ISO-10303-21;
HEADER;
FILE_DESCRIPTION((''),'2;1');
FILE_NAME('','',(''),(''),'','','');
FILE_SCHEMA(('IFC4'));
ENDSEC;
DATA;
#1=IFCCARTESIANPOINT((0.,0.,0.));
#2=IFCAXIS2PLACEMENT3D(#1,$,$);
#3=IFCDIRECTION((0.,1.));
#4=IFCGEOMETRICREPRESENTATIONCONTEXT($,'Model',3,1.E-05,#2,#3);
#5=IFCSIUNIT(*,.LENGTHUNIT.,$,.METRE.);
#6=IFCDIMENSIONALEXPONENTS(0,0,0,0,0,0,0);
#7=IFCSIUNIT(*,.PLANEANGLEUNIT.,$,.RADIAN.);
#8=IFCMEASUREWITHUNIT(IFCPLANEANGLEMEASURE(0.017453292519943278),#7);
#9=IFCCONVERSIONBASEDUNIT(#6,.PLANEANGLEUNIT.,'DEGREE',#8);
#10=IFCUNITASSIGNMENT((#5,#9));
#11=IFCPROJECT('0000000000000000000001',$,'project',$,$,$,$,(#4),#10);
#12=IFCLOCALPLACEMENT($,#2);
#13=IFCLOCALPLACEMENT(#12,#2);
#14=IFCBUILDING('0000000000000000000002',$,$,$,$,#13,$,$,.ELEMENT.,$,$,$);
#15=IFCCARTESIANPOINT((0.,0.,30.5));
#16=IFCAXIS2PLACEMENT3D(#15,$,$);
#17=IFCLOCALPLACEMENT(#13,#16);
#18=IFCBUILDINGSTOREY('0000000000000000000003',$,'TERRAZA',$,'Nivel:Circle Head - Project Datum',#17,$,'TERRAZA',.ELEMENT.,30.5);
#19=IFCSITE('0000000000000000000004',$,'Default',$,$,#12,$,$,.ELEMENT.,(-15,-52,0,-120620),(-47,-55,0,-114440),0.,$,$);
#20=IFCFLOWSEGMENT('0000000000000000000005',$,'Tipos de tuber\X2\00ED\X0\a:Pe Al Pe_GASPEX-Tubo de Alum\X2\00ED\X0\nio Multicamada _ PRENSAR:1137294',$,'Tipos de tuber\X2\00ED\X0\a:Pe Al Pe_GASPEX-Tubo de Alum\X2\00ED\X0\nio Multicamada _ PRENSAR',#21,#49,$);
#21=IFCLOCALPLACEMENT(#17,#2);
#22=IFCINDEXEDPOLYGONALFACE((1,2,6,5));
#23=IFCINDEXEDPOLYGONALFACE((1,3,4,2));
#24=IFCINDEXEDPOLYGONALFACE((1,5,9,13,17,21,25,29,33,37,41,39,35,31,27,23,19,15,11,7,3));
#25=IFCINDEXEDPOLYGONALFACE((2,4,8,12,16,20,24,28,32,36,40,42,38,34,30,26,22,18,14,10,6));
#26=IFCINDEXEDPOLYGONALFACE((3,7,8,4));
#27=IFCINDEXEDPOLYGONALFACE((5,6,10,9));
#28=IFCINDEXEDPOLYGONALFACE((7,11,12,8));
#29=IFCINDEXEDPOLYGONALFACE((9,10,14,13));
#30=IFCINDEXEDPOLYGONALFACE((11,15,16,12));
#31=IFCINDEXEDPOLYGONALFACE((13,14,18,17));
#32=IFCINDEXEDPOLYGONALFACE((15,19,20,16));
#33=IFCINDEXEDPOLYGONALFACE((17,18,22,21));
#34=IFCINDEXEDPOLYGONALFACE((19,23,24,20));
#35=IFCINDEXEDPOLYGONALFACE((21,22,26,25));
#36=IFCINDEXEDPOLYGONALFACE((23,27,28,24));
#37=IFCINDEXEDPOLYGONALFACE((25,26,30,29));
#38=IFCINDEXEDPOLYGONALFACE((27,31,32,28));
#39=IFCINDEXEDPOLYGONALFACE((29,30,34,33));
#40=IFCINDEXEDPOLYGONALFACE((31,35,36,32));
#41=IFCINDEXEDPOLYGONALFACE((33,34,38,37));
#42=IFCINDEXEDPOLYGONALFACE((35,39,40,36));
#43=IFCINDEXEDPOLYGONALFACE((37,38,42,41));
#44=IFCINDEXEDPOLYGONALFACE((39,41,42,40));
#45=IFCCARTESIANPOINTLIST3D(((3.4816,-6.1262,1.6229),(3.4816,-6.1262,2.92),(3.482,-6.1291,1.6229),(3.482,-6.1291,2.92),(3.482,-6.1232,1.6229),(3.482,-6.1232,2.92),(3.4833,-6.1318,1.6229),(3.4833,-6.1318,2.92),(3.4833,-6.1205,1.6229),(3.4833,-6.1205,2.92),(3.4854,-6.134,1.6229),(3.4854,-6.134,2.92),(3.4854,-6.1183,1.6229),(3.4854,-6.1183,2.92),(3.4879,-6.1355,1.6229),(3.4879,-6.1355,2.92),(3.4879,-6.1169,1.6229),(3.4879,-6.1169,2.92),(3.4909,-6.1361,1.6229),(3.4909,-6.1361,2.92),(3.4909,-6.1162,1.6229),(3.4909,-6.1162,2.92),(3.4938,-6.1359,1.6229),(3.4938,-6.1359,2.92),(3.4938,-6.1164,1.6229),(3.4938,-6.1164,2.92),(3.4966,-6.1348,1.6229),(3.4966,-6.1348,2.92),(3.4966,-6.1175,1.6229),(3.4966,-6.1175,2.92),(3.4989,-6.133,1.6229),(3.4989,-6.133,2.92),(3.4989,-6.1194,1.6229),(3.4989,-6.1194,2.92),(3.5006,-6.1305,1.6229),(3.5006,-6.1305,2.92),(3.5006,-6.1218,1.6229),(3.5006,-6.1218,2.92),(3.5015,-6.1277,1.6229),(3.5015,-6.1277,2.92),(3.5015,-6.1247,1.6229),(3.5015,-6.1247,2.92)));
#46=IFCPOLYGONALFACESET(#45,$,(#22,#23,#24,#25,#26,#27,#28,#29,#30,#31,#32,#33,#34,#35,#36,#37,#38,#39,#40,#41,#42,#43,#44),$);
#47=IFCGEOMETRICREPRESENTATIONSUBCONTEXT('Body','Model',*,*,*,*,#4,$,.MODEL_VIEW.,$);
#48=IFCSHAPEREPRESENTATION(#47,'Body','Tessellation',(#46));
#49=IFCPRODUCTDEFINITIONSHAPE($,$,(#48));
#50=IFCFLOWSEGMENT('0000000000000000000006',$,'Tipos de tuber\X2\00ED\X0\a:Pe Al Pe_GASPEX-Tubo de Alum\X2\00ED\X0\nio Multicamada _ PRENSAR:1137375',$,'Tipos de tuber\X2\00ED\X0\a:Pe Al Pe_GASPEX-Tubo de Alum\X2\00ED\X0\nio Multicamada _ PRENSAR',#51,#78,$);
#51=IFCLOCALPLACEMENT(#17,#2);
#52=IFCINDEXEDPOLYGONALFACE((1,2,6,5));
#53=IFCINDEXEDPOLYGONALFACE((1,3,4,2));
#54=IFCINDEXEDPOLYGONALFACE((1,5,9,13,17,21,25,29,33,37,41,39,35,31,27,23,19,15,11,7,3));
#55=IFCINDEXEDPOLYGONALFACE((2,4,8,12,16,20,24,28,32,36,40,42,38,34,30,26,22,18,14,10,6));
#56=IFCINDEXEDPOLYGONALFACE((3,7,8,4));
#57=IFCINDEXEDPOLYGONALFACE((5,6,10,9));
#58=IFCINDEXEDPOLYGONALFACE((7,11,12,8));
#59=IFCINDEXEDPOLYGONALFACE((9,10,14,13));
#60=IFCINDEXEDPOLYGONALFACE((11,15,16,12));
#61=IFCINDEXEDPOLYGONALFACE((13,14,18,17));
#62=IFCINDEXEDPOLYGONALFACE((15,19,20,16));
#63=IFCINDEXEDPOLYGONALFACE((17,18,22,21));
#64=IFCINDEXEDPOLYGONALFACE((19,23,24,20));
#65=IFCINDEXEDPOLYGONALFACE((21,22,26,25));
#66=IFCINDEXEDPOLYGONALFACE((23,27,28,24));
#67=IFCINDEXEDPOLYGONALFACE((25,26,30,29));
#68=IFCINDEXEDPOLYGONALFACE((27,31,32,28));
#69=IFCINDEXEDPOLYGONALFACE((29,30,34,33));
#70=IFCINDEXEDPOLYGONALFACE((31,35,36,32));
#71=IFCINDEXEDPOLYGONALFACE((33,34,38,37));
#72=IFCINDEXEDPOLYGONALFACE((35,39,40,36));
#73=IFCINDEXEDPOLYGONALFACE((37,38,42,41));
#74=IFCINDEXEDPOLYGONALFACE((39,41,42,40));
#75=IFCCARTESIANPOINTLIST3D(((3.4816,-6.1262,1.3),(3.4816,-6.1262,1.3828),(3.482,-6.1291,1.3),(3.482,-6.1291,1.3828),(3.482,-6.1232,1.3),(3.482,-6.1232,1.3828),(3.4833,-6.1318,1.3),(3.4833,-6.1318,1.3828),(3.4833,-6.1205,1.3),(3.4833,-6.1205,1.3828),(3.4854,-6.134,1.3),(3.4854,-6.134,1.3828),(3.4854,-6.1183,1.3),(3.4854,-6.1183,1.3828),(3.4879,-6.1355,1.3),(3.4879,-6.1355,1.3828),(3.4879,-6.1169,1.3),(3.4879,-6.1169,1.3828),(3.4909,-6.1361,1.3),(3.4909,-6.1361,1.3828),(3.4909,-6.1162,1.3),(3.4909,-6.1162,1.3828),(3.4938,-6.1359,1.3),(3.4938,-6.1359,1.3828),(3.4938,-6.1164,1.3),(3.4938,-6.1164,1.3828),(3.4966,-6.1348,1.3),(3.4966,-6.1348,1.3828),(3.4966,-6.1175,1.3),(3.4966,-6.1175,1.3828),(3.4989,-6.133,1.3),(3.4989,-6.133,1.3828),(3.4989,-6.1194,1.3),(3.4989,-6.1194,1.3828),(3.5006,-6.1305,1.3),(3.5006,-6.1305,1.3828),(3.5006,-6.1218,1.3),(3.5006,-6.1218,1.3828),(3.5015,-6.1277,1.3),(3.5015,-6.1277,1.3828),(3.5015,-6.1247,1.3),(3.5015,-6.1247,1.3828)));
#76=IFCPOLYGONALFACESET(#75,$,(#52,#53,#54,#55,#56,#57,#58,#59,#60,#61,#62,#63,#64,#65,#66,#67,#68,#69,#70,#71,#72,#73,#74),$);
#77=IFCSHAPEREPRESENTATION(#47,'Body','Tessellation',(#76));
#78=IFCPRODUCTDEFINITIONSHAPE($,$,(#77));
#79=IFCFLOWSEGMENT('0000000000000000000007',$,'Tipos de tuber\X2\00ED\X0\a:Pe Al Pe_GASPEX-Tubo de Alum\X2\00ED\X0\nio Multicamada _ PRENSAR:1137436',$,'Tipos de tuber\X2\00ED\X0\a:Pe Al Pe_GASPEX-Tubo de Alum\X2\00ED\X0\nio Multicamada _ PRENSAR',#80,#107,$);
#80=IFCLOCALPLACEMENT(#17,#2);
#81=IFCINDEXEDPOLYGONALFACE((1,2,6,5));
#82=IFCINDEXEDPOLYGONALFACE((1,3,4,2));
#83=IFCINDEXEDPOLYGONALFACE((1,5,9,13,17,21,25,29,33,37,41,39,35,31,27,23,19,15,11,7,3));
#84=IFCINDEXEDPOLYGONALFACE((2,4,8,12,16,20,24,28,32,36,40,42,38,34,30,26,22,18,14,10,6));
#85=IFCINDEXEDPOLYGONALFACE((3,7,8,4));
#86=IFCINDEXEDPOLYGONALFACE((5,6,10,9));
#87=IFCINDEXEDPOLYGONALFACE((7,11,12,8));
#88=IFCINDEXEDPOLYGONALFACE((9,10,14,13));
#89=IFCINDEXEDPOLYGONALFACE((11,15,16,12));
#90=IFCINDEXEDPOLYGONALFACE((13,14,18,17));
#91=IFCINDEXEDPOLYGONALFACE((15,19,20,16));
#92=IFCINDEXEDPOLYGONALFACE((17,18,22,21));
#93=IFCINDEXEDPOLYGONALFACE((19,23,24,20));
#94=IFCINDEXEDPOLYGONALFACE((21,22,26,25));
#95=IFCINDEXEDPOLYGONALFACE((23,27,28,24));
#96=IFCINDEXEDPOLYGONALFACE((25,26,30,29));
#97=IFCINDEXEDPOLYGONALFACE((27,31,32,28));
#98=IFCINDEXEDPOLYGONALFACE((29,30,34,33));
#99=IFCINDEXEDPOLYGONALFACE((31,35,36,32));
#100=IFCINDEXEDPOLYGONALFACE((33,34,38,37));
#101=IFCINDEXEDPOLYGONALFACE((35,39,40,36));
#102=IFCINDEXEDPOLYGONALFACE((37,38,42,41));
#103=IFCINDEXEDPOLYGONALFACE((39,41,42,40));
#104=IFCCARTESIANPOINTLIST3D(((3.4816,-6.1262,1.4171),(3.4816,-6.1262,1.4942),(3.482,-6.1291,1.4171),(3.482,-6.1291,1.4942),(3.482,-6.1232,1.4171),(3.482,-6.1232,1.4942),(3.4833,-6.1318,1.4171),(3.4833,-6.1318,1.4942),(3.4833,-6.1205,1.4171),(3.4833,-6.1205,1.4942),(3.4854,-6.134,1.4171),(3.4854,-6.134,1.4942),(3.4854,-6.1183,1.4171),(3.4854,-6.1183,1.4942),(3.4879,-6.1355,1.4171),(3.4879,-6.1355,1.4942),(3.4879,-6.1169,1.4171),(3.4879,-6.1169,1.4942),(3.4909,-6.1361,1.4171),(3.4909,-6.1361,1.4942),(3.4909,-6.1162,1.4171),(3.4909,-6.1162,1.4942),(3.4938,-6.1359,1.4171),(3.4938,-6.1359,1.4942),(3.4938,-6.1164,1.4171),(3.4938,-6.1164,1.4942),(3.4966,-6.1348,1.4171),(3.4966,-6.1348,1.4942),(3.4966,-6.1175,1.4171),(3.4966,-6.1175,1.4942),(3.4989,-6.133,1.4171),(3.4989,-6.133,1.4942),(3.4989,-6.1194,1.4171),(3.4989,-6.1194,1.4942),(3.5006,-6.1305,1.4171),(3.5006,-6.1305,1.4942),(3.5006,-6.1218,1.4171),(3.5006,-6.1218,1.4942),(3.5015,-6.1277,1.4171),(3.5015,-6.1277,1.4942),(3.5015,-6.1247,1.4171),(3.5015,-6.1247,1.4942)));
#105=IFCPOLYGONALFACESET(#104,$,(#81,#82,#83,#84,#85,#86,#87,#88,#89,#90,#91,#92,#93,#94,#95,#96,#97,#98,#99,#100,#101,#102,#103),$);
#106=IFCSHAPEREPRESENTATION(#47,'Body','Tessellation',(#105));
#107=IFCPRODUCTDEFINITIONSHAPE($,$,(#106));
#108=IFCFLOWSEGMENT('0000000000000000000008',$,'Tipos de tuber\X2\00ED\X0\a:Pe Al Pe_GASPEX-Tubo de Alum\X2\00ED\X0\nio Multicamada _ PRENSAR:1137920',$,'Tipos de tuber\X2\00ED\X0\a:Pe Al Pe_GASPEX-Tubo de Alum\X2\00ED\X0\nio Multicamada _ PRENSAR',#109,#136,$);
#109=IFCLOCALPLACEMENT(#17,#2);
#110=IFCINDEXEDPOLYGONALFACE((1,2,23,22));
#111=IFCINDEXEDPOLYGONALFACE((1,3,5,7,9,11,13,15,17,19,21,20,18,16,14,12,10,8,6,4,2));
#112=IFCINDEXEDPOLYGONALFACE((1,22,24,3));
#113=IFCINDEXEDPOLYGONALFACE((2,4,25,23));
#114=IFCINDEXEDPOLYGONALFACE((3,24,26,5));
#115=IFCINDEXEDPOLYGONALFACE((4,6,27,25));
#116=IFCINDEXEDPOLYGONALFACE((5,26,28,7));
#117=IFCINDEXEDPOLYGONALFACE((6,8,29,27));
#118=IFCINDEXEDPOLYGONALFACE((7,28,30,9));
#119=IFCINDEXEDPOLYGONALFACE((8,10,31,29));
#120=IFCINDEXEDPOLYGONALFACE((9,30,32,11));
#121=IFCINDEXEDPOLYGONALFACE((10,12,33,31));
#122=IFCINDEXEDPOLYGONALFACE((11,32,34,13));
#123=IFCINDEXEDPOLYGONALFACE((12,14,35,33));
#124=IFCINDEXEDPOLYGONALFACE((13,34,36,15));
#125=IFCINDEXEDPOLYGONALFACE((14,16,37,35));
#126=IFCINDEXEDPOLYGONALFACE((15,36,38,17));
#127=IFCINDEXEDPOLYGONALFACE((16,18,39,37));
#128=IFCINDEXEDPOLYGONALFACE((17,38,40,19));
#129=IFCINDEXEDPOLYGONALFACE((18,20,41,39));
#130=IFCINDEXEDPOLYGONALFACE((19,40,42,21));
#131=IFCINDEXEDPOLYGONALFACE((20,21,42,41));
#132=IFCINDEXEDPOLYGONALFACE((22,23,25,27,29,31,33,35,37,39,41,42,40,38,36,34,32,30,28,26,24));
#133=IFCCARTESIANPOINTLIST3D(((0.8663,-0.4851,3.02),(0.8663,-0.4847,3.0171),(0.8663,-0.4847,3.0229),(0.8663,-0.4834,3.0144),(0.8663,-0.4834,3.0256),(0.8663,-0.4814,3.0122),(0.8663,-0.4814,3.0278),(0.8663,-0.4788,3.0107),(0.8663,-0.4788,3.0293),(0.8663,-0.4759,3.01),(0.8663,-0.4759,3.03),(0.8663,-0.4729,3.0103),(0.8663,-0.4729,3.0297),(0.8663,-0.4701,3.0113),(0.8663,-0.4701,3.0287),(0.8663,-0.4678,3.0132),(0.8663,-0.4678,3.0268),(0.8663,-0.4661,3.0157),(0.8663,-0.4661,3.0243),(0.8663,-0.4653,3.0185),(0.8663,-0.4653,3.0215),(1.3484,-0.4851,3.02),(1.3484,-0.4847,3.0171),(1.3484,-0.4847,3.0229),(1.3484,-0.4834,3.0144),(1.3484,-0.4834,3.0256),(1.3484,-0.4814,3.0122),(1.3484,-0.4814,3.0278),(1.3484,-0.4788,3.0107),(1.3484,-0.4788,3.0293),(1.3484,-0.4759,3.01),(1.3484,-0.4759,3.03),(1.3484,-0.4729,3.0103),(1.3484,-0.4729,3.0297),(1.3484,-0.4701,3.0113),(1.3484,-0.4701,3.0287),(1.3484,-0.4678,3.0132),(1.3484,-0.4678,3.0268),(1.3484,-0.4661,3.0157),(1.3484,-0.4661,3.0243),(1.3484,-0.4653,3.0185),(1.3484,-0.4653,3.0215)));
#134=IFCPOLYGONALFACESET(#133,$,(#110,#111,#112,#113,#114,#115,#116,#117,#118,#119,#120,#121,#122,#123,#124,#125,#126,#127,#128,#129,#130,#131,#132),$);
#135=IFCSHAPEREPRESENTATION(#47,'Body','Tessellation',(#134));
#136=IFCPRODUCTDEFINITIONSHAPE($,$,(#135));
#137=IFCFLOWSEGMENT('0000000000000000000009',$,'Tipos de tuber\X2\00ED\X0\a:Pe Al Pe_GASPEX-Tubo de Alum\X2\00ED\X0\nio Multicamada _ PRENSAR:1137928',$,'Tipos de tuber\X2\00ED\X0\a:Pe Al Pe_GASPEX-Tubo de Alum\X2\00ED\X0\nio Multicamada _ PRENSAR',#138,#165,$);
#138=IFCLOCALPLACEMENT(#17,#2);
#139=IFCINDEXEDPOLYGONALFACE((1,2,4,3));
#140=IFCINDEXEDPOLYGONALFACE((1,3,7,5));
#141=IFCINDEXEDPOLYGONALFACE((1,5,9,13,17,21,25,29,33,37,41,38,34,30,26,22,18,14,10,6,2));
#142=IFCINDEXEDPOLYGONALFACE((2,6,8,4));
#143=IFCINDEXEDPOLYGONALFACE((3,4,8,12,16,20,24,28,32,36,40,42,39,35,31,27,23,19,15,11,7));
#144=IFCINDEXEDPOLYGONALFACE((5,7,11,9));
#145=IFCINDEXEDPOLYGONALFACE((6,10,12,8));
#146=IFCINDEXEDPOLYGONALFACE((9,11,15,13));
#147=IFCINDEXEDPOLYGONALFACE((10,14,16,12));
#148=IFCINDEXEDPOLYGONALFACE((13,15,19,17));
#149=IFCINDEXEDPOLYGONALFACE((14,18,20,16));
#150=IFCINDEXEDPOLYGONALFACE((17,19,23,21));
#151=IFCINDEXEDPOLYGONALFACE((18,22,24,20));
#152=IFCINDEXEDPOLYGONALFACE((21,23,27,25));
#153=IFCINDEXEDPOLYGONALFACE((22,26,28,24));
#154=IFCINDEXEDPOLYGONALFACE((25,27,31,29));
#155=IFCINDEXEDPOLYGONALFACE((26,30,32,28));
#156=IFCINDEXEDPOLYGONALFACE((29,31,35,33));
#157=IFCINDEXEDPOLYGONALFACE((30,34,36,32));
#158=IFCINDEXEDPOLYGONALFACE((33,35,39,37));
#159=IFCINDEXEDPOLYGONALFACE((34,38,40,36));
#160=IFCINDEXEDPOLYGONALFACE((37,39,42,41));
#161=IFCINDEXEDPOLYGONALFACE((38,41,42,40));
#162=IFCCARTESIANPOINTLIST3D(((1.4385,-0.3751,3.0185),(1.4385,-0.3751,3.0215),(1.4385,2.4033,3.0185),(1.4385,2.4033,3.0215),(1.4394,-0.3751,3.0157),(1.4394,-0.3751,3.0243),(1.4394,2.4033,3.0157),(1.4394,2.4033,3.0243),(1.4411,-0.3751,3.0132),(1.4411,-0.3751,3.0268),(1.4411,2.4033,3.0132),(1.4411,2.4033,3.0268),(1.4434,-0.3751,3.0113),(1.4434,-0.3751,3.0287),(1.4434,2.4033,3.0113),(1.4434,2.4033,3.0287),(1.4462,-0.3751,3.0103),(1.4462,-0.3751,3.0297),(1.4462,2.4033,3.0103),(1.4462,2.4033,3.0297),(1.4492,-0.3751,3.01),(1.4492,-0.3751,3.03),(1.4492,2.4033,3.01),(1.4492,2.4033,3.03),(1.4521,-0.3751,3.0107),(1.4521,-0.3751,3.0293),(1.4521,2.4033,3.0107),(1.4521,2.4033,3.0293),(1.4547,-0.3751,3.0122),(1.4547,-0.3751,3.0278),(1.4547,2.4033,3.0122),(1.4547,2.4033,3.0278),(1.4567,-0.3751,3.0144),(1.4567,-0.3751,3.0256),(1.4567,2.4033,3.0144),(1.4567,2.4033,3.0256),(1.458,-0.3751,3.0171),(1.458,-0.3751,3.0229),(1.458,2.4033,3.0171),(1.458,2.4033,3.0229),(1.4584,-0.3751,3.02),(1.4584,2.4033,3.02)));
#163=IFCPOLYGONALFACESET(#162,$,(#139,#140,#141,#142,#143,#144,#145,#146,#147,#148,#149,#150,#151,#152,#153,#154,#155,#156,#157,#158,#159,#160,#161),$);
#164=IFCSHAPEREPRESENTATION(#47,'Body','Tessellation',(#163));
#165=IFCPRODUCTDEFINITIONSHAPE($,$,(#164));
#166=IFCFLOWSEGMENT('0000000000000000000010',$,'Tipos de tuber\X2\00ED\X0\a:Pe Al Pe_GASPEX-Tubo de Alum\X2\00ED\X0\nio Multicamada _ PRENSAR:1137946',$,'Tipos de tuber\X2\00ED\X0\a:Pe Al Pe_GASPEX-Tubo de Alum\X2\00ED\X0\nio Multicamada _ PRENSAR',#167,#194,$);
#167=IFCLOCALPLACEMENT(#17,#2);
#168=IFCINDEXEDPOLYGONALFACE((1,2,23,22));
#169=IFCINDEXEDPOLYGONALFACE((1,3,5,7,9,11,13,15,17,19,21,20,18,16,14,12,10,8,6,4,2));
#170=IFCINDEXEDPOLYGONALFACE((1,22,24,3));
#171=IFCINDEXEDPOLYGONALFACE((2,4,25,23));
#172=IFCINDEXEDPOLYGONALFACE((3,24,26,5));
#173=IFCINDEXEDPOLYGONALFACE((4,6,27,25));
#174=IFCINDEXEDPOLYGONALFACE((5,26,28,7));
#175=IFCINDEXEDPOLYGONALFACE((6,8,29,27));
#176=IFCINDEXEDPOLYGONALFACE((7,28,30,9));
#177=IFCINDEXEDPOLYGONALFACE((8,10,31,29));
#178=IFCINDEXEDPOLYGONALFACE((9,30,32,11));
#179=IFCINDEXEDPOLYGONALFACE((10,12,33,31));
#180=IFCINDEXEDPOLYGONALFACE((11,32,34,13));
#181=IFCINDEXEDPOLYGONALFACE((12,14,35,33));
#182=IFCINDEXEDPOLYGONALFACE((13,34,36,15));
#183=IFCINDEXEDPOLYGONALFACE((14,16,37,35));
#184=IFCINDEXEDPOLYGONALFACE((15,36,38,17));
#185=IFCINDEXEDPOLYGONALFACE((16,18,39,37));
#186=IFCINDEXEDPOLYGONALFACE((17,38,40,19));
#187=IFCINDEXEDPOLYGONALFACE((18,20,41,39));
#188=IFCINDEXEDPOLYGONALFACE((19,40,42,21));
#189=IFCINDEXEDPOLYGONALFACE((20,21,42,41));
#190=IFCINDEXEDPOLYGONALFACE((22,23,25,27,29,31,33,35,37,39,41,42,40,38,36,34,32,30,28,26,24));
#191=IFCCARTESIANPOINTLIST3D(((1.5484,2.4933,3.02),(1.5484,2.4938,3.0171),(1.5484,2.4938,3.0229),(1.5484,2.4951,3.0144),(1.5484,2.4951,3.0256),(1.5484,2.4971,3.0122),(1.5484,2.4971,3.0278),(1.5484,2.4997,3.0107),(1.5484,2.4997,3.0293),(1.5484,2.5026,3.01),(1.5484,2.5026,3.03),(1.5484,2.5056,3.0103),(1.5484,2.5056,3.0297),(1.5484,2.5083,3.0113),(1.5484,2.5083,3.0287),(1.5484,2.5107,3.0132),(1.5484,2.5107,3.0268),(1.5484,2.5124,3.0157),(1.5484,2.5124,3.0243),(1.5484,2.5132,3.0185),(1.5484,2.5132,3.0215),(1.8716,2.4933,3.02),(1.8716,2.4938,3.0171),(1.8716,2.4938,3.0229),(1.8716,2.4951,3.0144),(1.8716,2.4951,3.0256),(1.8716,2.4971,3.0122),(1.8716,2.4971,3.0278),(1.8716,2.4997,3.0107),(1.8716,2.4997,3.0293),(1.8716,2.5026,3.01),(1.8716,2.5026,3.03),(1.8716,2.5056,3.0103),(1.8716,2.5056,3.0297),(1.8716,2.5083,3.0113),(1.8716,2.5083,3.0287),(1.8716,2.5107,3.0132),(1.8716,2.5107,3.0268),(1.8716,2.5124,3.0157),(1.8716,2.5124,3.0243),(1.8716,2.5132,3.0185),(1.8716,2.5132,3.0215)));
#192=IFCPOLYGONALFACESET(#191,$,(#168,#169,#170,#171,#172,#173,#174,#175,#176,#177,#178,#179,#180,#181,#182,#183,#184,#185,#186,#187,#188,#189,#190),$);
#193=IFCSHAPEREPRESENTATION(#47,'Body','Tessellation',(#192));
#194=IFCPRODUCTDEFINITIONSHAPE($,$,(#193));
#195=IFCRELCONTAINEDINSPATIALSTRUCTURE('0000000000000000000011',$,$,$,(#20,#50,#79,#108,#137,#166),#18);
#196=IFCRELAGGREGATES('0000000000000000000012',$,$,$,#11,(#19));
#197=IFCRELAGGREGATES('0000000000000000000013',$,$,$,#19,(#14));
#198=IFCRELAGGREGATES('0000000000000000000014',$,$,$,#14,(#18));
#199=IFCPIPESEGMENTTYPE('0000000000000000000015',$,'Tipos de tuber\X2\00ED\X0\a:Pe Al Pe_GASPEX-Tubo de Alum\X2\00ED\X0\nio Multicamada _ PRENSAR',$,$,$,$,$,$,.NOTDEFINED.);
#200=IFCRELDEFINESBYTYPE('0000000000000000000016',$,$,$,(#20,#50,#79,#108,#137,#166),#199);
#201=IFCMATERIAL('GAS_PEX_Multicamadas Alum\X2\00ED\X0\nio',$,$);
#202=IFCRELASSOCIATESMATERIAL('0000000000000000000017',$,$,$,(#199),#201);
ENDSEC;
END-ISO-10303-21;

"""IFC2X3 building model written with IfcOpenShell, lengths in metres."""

from ifc_helpers import new_model, entity, si_unit, converted_unit, direction, frame, origin, origin_2d_with_axis, place, context, subcontext, project, spatial, circle, extrude, material, type_object, element, save


model = new_model("IFC2X3")

# Units and contexts
model_context = context("Model", 3, precision=1e-05, world=origin(), true_north=direction((0.0, 1.0)))
body_context = subcontext(model_context, "Body", "Model", "MODEL_VIEW")
ifc_project = project(units=[si_unit("LENGTHUNIT", "METRE"), converted_unit("PLANEANGLEUNIT", "DEGREE", entity("IfcPlaneAngleMeasure", 0.017453292519943278), si_unit("PLANEANGLEUNIT", "RADIAN"), dimensions=[0, 0, 0, 0, 0, 0, 0])], contexts=[model_context])

# Site, building, storey
site_placement = place(None, origin())
site = spatial("IfcSite", under=ifc_project, at=site_placement, Name="Default", CompositionType="ELEMENT", RefLatitude=(-15, -52, 0, -120620), RefLongitude=(-47, -55, 0, -114440), RefElevation=0.0)
building_placement = place(site_placement, origin())
building = spatial("IfcBuilding", under=site, at=building_placement, CompositionType="ELEMENT")
storey_placement = place(building_placement, frame((0.0, 0.0, 30.5)))
storey = spatial("IfcBuildingStorey", under=building, at=storey_placement, Name="TERRAZA", ObjectType="Nivel:Circle Head - Project Datum", LongName="TERRAZA", CompositionType="ELEMENT", Elevation=30.5)

# Flow segments
ifc_material = material(Name="GAS_PEX_Multicamadas Alumínio")
pipe_segment_type = type_object("IfcPipeSegmentType", Name="Tipos de tubería:Pe Al Pe_GASPEX-Tubo de Alumínio Multicamada _ PRENSAR", PredefinedType="NOTDEFINED", material=ifc_material)
flow_segment_1_placement = place(storey_placement, origin())
element("IfcFlowSegment", 1, at=flow_segment_1_placement, inside=storey, type_object=pipe_segment_type, Name="Tipos de tubería:Pe Al Pe_GASPEX-Tubo de Alumínio Multicamada _ PRENSAR:1137294", ObjectType="Tipos de tubería:Pe Al Pe_GASPEX-Tubo de Alumínio Multicamada _ PRENSAR", context=body_context, shape_type="SweptSolid", body=[
    extrude(circle(Radius=0.01, at=origin_2d_with_axis()), frame((3.4916, -6.1262, 1.6229), z_axis=(0.0, 0.0, 1.0), x_axis=(-1.0, 0.0, 0.0)), (0.0, 0.0, 1.0), 1.2971),
])
flow_segment_2_placement = place(storey_placement, origin())
element("IfcFlowSegment", 2, at=flow_segment_2_placement, inside=storey, type_object=pipe_segment_type, Name="Tipos de tubería:Pe Al Pe_GASPEX-Tubo de Alumínio Multicamada _ PRENSAR:1137375", ObjectType="Tipos de tubería:Pe Al Pe_GASPEX-Tubo de Alumínio Multicamada _ PRENSAR", context=body_context, shape_type="SweptSolid", body=[
    extrude(circle(Radius=0.01, at=origin_2d_with_axis()), frame((3.4916, -6.1262, 1.3), z_axis=(0.0, 0.0, 1.0), x_axis=(-1.0, 0.0, 0.0)), (0.0, 0.0, 1.0), 0.0828),
])
flow_segment_3_placement = place(storey_placement, origin())
element("IfcFlowSegment", 3, at=flow_segment_3_placement, inside=storey, type_object=pipe_segment_type, Name="Tipos de tubería:Pe Al Pe_GASPEX-Tubo de Alumínio Multicamada _ PRENSAR:1137436", ObjectType="Tipos de tubería:Pe Al Pe_GASPEX-Tubo de Alumínio Multicamada _ PRENSAR", context=body_context, shape_type="SweptSolid", body=[
    extrude(circle(Radius=0.01, at=origin_2d_with_axis()), frame((3.4916, -6.1262, 1.4171), z_axis=(0.0, 0.0, 1.0), x_axis=(-1.0, 0.0, 0.0)), (0.0, 0.0, 1.0), 0.077),
])
flow_segment_4_placement = place(storey_placement, origin())
element("IfcFlowSegment", 4, at=flow_segment_4_placement, inside=storey, type_object=pipe_segment_type, Name="Tipos de tubería:Pe Al Pe_GASPEX-Tubo de Alumínio Multicamada _ PRENSAR:1137920", ObjectType="Tipos de tubería:Pe Al Pe_GASPEX-Tubo de Alumínio Multicamada _ PRENSAR", context=body_context, shape_type="SweptSolid", body=[
    extrude(circle(Radius=0.01, at=origin_2d_with_axis()), frame((0.8663, -0.4751, 3.02), z_axis=(1.0, 0.0, 0.0), x_axis=(0.0, -1.0, 0.0)), (0.0, 0.0, 1.0), 0.4822),
])
flow_segment_5_placement = place(storey_placement, origin())
element("IfcFlowSegment", 5, at=flow_segment_5_placement, inside=storey, type_object=pipe_segment_type, Name="Tipos de tubería:Pe Al Pe_GASPEX-Tubo de Alumínio Multicamada _ PRENSAR:1137928", ObjectType="Tipos de tubería:Pe Al Pe_GASPEX-Tubo de Alumínio Multicamada _ PRENSAR", context=body_context, shape_type="SweptSolid", body=[
    extrude(circle(Radius=0.01, at=origin_2d_with_axis()), frame((1.4484, -0.3751, 3.02), z_axis=(0.0, 1.0, 0.0), x_axis=(1.0, 0.0, 0.0)), (0.0, 0.0, 1.0), 2.7785),
])
flow_segment_6_placement = place(storey_placement, origin())
element("IfcFlowSegment", 6, at=flow_segment_6_placement, inside=storey, type_object=pipe_segment_type, Name="Tipos de tubería:Pe Al Pe_GASPEX-Tubo de Alumínio Multicamada _ PRENSAR:1137946", ObjectType="Tipos de tubería:Pe Al Pe_GASPEX-Tubo de Alumínio Multicamada _ PRENSAR", context=body_context, shape_type="SweptSolid", body=[
    extrude(circle(Radius=0.01, at=origin_2d_with_axis()), frame((1.5484, 2.5033, 3.02), z_axis=(1.0, 0.0, 0.0), x_axis=(0.0, -1.0, 0.0)), (0.0, 0.0, 1.0), 0.3232),
])

save(model, "model.ifc")
